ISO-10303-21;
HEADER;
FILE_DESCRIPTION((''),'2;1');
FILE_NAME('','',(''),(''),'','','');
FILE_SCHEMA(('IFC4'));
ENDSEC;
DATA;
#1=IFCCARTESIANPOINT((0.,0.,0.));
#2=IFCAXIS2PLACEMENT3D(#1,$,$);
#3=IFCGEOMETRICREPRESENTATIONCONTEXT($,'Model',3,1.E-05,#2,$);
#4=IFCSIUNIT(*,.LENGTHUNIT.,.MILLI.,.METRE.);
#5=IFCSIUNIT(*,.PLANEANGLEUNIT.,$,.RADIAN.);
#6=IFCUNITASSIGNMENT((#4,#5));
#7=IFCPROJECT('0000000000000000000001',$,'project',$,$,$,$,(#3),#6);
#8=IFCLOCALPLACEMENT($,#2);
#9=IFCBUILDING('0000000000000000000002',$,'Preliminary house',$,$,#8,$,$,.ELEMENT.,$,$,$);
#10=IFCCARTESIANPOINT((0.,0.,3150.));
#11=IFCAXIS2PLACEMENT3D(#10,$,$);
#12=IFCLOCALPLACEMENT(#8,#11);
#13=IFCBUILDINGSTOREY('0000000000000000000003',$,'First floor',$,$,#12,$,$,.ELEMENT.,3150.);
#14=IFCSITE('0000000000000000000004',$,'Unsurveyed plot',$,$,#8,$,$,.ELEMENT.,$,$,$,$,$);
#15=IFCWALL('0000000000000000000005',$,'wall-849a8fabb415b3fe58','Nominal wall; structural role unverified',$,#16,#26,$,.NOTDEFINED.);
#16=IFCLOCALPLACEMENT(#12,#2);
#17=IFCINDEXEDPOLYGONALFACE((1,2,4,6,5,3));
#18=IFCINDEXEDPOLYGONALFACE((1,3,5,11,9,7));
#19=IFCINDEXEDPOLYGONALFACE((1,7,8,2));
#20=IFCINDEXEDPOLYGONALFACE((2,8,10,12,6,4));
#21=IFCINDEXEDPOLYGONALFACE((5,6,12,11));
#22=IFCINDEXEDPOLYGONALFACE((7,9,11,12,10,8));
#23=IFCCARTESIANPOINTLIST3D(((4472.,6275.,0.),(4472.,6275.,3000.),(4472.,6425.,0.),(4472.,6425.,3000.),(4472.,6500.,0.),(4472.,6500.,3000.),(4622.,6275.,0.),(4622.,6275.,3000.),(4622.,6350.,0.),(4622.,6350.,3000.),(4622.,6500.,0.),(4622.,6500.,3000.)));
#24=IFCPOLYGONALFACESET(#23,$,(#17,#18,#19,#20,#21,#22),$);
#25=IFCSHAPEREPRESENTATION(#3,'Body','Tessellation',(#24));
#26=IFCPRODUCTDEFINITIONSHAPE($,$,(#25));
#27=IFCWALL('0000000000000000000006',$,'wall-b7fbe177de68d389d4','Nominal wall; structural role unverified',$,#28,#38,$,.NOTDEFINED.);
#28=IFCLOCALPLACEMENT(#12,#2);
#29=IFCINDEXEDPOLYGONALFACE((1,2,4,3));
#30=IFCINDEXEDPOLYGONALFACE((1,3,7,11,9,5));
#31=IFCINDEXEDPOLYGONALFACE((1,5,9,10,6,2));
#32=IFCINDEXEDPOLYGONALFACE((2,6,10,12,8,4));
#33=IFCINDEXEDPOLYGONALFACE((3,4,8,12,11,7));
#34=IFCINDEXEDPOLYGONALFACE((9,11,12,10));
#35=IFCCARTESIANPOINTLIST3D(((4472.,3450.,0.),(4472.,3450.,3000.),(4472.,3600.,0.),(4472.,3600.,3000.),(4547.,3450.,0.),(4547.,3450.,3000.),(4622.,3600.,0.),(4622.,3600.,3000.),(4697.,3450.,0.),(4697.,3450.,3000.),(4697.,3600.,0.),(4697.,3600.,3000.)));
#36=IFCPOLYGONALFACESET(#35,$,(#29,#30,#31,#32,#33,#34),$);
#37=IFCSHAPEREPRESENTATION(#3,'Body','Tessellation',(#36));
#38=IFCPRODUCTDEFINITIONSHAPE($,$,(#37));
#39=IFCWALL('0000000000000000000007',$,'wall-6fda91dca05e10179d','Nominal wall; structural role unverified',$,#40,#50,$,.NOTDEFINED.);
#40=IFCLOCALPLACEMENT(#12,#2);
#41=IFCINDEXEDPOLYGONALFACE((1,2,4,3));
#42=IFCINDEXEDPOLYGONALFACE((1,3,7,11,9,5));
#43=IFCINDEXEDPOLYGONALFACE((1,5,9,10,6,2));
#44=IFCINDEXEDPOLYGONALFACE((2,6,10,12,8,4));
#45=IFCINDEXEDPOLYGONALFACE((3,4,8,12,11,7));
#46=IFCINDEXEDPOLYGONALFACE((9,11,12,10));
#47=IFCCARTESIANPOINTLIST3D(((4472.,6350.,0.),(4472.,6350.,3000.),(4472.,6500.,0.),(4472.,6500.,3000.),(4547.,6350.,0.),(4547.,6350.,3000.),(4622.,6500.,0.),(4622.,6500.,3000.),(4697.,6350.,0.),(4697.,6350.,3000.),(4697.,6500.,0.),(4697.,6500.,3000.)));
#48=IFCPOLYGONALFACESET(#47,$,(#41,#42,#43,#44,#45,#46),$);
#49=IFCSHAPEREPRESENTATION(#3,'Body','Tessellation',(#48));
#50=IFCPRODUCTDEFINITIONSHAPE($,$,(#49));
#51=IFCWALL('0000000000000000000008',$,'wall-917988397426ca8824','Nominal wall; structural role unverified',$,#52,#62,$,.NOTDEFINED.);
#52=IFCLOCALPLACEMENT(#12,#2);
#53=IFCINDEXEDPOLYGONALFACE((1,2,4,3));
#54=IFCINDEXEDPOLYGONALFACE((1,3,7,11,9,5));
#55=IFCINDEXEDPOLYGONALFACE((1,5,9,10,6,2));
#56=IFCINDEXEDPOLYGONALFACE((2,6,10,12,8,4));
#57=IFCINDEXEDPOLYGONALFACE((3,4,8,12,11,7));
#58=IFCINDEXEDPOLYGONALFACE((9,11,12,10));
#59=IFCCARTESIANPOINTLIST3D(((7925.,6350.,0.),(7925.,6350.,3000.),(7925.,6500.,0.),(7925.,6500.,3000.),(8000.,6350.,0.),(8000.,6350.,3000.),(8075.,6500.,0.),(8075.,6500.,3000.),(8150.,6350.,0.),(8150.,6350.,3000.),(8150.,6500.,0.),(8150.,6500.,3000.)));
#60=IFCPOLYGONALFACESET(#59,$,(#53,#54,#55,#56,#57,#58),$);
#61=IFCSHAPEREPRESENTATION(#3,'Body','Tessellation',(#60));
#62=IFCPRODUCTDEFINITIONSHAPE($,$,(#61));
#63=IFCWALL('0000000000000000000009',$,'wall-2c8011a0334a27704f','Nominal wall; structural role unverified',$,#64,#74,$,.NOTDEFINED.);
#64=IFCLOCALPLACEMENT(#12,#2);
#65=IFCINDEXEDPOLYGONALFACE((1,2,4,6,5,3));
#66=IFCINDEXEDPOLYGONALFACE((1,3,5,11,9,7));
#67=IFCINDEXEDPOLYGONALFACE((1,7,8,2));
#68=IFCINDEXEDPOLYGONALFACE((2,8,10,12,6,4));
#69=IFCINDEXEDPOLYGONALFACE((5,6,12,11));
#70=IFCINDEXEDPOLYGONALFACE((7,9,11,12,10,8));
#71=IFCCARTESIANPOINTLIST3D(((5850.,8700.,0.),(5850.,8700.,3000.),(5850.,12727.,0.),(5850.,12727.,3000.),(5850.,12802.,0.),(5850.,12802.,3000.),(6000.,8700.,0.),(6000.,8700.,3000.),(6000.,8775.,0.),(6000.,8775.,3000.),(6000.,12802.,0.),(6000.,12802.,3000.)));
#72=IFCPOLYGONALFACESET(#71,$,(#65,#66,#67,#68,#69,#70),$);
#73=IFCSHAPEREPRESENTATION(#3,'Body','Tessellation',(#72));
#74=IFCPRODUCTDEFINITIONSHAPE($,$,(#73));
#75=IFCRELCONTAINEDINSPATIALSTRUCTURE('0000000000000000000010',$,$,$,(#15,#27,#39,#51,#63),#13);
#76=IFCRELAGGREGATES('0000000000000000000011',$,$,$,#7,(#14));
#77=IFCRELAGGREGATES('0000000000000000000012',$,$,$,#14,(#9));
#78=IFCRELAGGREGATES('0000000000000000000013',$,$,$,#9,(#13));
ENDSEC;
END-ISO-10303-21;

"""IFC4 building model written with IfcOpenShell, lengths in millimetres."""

from ifc_helpers import new_model, si_unit, frame, origin, place, context, project, spatial, polyline, outline, extrude, element, save


model = new_model("IFC4")

# Units and contexts
model_context = context("Model", 3, precision=1e-05, world=origin())
ifc_project = project(units=[si_unit("LENGTHUNIT", "METRE", prefix="MILLI"), si_unit("PLANEANGLEUNIT", "RADIAN")], contexts=[model_context])

# Site, building, storey
placement_1 = place(None, origin())
site = spatial("IfcSite", under=ifc_project, at=placement_1, Name="Unsurveyed plot", CompositionType="ELEMENT")
building = spatial("IfcBuilding", under=site, at=placement_1, Name="Preliminary house", CompositionType="ELEMENT")
placement_2 = place(placement_1, frame((0.0, 0.0, 3150.0)))
storey = spatial("IfcBuildingStorey", under=building, at=placement_2, Name="First floor", CompositionType="ELEMENT", Elevation=3150.0)

# Walls
element("IfcWall", 1, at=placement_2, inside=storey, Name="wall-849a8fabb415b3fe58", Description="Nominal wall; structural role unverified", PredefinedType="NOTDEFINED", context=model_context, shape_type="SweptSolid", body=[
    extrude(outline(polyline([(4472.0, 6425.0), (4472.0, 6500.0), (4622.0, 6500.0), (4622.0, 6350.0), (4622.0, 6275.0), (4472.0, 6275.0), (4472.0, 6425.0)])), origin(), (0.0, 0.0, 1.0), 3000.0),
])
element("IfcWall", 2, at=placement_2, inside=storey, Name="wall-b7fbe177de68d389d4", Description="Nominal wall; structural role unverified", PredefinedType="NOTDEFINED", context=model_context, shape_type="SweptSolid", body=[
    extrude(outline(polyline([(4622.0, 3600.0), (4697.0, 3600.0), (4697.0, 3450.0), (4547.0, 3450.0), (4472.0, 3450.0), (4472.0, 3600.0), (4622.0, 3600.0)])), origin(), (0.0, 0.0, 1.0), 3000.0),
])
element("IfcWall", 3, at=placement_2, inside=storey, Name="wall-6fda91dca05e10179d", Description="Nominal wall; structural role unverified", PredefinedType="NOTDEFINED", context=model_context, shape_type="SweptSolid", body=[
    extrude(outline(polyline([(4622.0, 6500.0), (4697.0, 6500.0), (4697.0, 6350.0), (4547.0, 6350.0), (4472.0, 6350.0), (4472.0, 6500.0), (4622.0, 6500.0)])), origin(), (0.0, 0.0, 1.0), 3000.0),
])
element("IfcWall", 4, at=placement_2, inside=storey, Name="wall-917988397426ca8824", Description="Nominal wall; structural role unverified", PredefinedType="NOTDEFINED", context=model_context, shape_type="SweptSolid", body=[
    extrude(outline(polyline([(8075.0, 6500.0), (8150.0, 6500.0), (8150.0, 6350.0), (8000.0, 6350.0), (7925.0, 6350.0), (7925.0, 6500.0), (8075.0, 6500.0)])), origin(), (0.0, 0.0, 1.0), 3000.0),
])
element("IfcWall", 5, at=placement_2, inside=storey, Name="wall-2c8011a0334a27704f", Description="Nominal wall; structural role unverified", PredefinedType="NOTDEFINED", context=model_context, shape_type="SweptSolid", body=[
    extrude(outline(polyline([(5850.0, 12727.0), (5850.0, 12802.0), (6000.0, 12802.0), (6000.0, 8775.0), (6000.0, 8700.0), (5850.0, 8700.0), (5850.0, 12727.0)])), origin(), (0.0, 0.0, 1.0), 3000.0),
])

save(model, "model.ifc")
